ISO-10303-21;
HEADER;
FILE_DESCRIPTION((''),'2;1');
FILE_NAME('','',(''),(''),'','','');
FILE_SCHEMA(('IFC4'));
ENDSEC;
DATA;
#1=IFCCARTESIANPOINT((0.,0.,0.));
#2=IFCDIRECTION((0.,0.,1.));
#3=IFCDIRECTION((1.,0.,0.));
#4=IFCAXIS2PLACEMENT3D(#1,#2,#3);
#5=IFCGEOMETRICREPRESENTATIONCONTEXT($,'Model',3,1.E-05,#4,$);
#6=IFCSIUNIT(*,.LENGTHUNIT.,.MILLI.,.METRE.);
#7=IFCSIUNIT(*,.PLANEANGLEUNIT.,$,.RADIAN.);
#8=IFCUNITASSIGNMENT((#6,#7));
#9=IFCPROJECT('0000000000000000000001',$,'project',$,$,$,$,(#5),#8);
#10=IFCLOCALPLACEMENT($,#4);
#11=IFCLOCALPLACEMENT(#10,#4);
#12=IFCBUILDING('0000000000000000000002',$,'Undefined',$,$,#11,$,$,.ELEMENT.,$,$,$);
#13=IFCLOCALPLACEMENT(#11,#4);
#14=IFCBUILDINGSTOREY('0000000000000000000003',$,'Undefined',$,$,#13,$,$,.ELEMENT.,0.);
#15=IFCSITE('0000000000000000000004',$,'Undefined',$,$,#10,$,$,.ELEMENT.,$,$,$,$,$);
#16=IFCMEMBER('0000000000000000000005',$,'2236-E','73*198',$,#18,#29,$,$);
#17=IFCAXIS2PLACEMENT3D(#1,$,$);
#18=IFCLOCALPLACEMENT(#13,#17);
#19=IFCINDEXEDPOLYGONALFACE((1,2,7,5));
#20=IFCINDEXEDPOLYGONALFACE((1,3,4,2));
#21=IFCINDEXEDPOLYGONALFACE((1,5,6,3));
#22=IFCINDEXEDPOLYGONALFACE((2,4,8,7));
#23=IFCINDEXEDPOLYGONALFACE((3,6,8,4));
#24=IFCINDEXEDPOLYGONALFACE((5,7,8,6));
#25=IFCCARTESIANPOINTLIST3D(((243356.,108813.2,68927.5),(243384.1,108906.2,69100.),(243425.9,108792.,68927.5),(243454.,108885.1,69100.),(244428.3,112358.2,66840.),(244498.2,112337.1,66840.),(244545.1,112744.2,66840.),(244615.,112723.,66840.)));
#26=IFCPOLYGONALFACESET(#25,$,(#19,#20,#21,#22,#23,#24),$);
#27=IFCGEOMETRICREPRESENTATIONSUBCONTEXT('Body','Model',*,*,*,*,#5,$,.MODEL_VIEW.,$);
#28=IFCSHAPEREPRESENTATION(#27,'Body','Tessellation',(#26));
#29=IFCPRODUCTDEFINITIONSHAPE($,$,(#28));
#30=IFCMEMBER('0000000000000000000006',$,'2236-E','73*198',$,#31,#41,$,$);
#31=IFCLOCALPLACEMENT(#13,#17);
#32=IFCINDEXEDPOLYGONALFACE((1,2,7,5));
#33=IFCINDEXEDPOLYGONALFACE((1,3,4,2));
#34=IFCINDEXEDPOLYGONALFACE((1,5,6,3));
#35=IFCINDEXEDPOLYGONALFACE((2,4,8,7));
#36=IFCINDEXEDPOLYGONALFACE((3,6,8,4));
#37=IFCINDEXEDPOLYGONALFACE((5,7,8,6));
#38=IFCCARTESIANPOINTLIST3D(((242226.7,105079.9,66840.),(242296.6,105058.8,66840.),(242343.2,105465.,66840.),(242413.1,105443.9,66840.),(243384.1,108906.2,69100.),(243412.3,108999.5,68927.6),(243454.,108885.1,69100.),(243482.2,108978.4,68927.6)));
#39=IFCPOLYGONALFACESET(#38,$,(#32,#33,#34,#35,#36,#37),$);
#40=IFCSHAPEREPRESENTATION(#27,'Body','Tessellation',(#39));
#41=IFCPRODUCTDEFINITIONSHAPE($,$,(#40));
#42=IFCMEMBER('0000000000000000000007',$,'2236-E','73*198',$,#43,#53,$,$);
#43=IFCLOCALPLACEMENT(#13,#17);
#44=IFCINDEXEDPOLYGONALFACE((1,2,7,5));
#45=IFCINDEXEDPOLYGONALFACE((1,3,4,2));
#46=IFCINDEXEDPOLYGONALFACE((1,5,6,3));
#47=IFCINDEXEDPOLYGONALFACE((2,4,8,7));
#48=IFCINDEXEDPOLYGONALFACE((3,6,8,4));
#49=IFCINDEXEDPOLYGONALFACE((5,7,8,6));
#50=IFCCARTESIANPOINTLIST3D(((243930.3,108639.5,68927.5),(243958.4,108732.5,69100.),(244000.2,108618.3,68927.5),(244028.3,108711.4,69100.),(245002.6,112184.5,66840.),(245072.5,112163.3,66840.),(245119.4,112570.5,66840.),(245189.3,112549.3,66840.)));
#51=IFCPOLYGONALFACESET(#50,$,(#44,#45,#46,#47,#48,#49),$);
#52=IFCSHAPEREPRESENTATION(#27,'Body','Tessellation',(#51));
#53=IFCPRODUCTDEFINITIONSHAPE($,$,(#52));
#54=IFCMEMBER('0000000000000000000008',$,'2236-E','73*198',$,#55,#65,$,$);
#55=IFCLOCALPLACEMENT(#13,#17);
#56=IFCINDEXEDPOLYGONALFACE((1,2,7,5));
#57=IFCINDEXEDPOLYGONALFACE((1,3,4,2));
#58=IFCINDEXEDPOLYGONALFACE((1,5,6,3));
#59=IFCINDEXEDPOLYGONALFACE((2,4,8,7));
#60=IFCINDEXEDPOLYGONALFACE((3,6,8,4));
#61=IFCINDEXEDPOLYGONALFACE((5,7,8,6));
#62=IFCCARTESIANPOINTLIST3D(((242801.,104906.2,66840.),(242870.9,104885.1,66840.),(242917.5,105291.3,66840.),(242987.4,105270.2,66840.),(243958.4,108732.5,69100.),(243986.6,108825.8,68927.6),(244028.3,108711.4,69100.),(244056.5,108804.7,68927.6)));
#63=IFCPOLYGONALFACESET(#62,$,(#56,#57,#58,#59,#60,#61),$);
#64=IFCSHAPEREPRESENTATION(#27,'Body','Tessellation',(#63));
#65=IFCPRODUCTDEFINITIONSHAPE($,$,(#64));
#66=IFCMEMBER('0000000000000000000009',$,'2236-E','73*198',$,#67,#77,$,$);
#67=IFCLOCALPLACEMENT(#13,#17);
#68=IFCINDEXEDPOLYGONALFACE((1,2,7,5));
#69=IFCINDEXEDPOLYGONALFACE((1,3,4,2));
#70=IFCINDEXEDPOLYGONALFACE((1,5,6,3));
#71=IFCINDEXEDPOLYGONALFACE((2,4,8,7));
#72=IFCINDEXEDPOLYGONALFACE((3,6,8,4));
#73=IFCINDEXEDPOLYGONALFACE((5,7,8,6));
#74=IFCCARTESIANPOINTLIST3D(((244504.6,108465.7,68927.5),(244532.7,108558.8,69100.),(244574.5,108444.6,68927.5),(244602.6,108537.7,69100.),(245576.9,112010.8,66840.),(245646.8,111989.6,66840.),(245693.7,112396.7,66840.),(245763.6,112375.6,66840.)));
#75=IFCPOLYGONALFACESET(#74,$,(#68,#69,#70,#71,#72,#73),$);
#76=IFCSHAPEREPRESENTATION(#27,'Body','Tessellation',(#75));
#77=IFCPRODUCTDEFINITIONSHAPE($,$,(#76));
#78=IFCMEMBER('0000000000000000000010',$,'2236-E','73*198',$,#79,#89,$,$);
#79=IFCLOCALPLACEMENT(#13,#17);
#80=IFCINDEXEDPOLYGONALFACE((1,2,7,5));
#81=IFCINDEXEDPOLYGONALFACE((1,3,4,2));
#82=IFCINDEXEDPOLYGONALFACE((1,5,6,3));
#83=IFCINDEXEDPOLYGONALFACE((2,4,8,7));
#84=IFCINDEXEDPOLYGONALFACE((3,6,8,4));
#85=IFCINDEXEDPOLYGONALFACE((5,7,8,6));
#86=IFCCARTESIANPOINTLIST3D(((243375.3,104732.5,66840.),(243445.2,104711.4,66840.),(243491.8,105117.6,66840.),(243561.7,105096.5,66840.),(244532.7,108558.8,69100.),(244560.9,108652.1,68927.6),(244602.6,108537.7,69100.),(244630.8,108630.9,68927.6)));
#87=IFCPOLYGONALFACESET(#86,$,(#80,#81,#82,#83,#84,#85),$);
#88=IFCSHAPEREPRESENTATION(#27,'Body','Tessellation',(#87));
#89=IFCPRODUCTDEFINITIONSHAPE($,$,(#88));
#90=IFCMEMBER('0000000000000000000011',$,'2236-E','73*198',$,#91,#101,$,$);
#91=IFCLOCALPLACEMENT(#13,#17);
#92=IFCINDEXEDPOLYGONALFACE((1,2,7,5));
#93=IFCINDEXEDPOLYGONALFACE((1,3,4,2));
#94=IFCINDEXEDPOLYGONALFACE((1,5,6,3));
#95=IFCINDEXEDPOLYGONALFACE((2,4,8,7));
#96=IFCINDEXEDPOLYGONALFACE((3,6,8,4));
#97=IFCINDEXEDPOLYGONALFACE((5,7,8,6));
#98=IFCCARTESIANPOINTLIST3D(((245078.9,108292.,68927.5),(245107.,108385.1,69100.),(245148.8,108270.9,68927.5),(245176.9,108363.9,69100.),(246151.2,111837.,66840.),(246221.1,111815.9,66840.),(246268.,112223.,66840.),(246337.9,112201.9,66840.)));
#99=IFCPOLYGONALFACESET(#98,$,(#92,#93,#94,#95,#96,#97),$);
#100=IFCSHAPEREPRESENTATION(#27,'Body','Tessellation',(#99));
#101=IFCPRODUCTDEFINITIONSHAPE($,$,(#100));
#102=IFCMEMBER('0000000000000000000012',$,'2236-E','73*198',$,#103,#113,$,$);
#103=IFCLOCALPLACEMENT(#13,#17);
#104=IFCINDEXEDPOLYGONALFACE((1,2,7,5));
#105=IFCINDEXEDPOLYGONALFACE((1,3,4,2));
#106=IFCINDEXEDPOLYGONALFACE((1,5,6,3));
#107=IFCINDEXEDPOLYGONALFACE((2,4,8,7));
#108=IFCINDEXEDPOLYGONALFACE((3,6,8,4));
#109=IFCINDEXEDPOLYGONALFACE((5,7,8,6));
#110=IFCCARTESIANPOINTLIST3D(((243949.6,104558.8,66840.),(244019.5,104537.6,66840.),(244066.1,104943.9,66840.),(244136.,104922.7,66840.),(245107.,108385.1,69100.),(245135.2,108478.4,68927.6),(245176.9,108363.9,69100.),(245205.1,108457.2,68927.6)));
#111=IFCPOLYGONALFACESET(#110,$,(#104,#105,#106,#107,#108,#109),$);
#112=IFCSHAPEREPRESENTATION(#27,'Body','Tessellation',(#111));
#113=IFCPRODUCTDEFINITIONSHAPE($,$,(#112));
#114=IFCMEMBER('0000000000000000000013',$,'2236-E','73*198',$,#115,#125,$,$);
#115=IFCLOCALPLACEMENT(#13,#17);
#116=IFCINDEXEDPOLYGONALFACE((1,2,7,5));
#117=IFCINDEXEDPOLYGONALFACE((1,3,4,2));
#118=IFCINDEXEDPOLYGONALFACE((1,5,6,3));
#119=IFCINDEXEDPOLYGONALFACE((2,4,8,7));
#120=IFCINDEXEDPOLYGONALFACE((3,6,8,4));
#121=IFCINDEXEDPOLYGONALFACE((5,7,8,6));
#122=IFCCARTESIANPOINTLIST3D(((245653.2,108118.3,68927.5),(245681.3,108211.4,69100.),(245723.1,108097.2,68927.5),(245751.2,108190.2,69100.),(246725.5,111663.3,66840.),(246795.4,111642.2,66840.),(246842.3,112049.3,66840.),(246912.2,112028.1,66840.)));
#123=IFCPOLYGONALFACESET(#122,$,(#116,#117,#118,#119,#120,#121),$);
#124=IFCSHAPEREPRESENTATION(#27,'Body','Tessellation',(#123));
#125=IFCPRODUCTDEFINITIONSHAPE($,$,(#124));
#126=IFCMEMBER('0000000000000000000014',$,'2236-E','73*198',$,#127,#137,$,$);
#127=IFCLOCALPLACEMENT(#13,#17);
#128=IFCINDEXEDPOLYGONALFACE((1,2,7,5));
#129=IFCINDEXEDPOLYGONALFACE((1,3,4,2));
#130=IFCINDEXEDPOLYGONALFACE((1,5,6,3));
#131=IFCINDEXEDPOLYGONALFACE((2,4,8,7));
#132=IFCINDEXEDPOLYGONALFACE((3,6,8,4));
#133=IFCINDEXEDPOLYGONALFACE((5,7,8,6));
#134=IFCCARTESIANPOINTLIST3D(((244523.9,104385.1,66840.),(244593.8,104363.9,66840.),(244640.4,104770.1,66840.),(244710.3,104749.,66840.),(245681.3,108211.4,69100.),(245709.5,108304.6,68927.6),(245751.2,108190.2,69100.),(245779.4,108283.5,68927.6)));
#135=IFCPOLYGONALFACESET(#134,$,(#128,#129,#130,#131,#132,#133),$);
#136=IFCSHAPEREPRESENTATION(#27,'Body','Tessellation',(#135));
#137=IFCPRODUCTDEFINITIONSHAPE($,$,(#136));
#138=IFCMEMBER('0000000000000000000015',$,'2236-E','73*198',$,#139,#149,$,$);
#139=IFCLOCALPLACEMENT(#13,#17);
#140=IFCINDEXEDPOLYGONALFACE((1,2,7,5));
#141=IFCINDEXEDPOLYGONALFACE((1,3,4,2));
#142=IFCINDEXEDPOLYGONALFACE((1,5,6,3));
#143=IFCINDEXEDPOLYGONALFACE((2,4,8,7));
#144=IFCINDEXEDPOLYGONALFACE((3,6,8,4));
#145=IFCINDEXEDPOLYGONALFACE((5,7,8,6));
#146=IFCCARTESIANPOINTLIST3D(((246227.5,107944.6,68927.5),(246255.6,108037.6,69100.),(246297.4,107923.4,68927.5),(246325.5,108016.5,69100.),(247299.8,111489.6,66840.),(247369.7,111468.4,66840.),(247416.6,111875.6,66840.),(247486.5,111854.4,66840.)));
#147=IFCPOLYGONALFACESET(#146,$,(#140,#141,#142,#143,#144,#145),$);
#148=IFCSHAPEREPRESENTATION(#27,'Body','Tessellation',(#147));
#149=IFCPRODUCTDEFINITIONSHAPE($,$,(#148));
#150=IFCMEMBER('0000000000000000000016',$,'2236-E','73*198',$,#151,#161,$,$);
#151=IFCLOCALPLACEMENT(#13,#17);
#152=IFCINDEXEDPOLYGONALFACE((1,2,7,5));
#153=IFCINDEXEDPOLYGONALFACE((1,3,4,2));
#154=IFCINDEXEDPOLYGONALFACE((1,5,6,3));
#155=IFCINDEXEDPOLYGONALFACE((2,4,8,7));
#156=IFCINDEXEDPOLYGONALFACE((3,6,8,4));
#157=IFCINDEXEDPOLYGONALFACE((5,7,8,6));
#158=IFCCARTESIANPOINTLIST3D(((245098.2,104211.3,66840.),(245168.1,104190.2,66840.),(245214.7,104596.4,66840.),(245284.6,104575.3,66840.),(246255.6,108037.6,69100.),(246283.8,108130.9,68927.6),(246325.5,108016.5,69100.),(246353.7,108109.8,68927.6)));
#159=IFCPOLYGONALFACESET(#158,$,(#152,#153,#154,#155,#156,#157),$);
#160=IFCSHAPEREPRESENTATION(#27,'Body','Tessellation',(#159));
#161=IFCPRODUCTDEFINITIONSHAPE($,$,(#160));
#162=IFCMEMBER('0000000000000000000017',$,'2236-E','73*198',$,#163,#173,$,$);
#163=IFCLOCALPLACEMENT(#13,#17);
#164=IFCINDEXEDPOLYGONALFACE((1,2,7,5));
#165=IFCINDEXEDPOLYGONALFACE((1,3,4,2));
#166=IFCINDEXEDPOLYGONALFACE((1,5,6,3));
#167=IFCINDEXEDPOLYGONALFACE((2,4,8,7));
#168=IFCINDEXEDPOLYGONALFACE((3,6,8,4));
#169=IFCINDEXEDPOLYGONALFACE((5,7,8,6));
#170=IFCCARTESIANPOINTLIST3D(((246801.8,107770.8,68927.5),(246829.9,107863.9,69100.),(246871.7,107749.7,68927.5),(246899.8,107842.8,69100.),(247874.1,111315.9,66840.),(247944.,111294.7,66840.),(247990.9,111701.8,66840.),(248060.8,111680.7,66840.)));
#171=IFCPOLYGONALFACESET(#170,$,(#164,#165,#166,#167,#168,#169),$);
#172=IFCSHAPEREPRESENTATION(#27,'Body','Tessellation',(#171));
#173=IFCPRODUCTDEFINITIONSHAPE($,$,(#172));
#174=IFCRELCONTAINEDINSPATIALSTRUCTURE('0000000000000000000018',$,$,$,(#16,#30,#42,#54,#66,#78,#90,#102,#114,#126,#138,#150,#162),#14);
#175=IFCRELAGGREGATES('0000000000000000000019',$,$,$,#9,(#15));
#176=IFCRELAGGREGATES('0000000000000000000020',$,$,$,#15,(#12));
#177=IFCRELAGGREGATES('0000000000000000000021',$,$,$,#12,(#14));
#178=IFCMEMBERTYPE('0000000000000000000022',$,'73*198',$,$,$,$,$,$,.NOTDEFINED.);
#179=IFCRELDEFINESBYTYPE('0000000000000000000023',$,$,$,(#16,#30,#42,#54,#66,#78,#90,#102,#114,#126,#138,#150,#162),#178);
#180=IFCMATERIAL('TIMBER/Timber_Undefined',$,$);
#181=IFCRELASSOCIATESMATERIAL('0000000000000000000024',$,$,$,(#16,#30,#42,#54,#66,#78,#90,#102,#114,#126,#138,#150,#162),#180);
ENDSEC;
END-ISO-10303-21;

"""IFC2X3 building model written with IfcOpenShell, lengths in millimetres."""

from ifc_helpers import new_model, si_unit, frame, origin_with_axes, origin_2d_with_axis, place, context, subcontext, project, spatial, rectangle, extrude, clip, halfspace, material, type_object, element, save


model = new_model("IFC2X3")

# Units and contexts
model_context = context("Model", 3, precision=1e-05, world=origin_with_axes())
body_context = subcontext(model_context, "Body", "Model", "MODEL_VIEW")
ifc_project = project(units=[si_unit("LENGTHUNIT", "METRE", prefix="MILLI"), si_unit("PLANEANGLEUNIT", "RADIAN")], contexts=[model_context])

# Site, building, storey
site_placement = place(None, origin_with_axes())
site = spatial("IfcSite", under=ifc_project, at=site_placement, Name="Undefined", CompositionType="ELEMENT")
building_placement = place(site_placement, origin_with_axes())
building = spatial("IfcBuilding", under=site, at=building_placement, Name="Undefined", CompositionType="ELEMENT")
storey_placement = place(building_placement, origin_with_axes())
storey = spatial("IfcBuildingStorey", under=building, at=storey_placement, Name="Undefined", CompositionType="ELEMENT", Elevation=0.0)

# Shared definitions
ifc_material_1 = material(Name="TIMBER/Timber_Undefined")

# Members
member_type = type_object("IfcMemberType", Name="73*198", PredefinedType="NOTDEFINED")
member_1_placement = place(storey_placement, frame((243405.0, 108849.1, 69013.8), z_axis=(-0.957167, 0.289538, 0.0), x_axis=(0.252232, 0.833838, -0.491013)))
element("IfcMember", 1, at=member_1_placement, inside=storey, type_object=member_type, material=ifc_material_1, Name="2236-E", Description="73*198", context=body_context, shape_type="Clipping", body=[
    clip(extrude(rectangle(XDim=198.0, YDim=73.0, at=origin_2d_with_axis()), frame((9470.2, 0.0, 0.0), z_axis=(-1.0, 0.0, 0.0), x_axis=(0.0, -1.0, 0.0)), (0.0, 0.0, 1.0), 9470.2), halfspace(frame((4746.2, -179.9, -36.5), z_axis=(0.491013, 0.871152, 0.0), x_axis=(0.0, 0.0, 1.0)), False)),
])
member_2_placement = place(storey_placement, frame((243433.2, 108942.3, 69013.8), z_axis=(-0.957167, 0.289538, 0.0), x_axis=(-0.252047, -0.833226, -0.492144)))
element("IfcMember", 2, at=member_2_placement, inside=storey, type_object=member_type, material=ifc_material_1, Name="2236-E", Description="73*198", context=body_context, shape_type="Clipping", body=[
    clip(extrude(rectangle(XDim=198.0, YDim=73.0, at=origin_2d_with_axis()), frame((9448.4, 0.0, 0.0), z_axis=(-1.0, 0.0, 0.0), x_axis=(0.0, -1.0, 0.0)), (0.0, 0.0, 1.0), 9448.5), halfspace(frame((4746.1, 186.1, 36.5), z_axis=(0.492144, -0.870514, 0.0), x_axis=(0.0, 0.0, -1.0)), False)),
])
member_3_placement = place(storey_placement, frame((243979.3, 108675.4, 69013.8), z_axis=(-0.957167, 0.289538, 0.0), x_axis=(0.252232, 0.833838, -0.491013)))
element("IfcMember", 3, at=member_3_placement, inside=storey, type_object=member_type, material=ifc_material_1, Name="2236-E", Description="73*198", context=body_context, shape_type="Clipping", body=[
    clip(extrude(rectangle(XDim=198.0, YDim=73.0, at=origin_2d_with_axis()), frame((9470.2, 0.0, 0.0), z_axis=(-1.0, 0.0, 0.0), x_axis=(0.0, -1.0, 0.0)), (0.0, 0.0, 1.0), 9470.2), halfspace(frame((4746.2, -179.9, -36.5), z_axis=(0.491013, 0.871152, 0.0), x_axis=(0.0, 0.0, 1.0)), False)),
])
member_4_placement = place(storey_placement, frame((244007.5, 108768.6, 69013.8), z_axis=(-0.957167, 0.289538, 0.0), x_axis=(-0.252047, -0.833226, -0.492144)))
element("IfcMember", 4, at=member_4_placement, inside=storey, type_object=member_type, material=ifc_material_1, Name="2236-E", Description="73*198", context=body_context, shape_type="Clipping", body=[
    clip(extrude(rectangle(XDim=198.0, YDim=73.0, at=origin_2d_with_axis()), frame((9448.4, 0.0, 0.0), z_axis=(-1.0, 0.0, 0.0), x_axis=(0.0, -1.0, 0.0)), (0.0, 0.0, 1.0), 9448.5), halfspace(frame((4746.1, 186.1, 36.5), z_axis=(0.492144, -0.870514, 0.0), x_axis=(0.0, 0.0, -1.0)), False)),
])
member_5_placement = place(storey_placement, frame((244553.6, 108501.7, 69013.8), z_axis=(-0.957167, 0.289538, 0.0), x_axis=(0.252232, 0.833838, -0.491013)))
element("IfcMember", 5, at=member_5_placement, inside=storey, type_object=member_type, material=ifc_material_1, Name="2236-E", Description="73*198", context=body_context, shape_type="Clipping", body=[
    clip(extrude(rectangle(XDim=198.0, YDim=73.0, at=origin_2d_with_axis()), frame((9470.2, 0.0, 0.0), z_axis=(-1.0, 0.0, 0.0), x_axis=(0.0, -1.0, 0.0)), (0.0, 0.0, 1.0), 9470.2), halfspace(frame((4746.2, -179.9, -36.5), z_axis=(0.491013, 0.871152, 0.0), x_axis=(0.0, 0.0, 1.0)), False)),
])
member_6_placement = place(storey_placement, frame((244581.8, 108594.9, 69013.8), z_axis=(-0.957167, 0.289538, 0.0), x_axis=(-0.252047, -0.833226, -0.492144)))
element("IfcMember", 6, at=member_6_placement, inside=storey, type_object=member_type, material=ifc_material_1, Name="2236-E", Description="73*198", context=body_context, shape_type="Clipping", body=[
    clip(extrude(rectangle(XDim=198.0, YDim=73.0, at=origin_2d_with_axis()), frame((9448.4, 0.0, 0.0), z_axis=(-1.0, 0.0, 0.0), x_axis=(0.0, -1.0, 0.0)), (0.0, 0.0, 1.0), 9448.5), halfspace(frame((4746.1, 186.1, 36.5), z_axis=(0.492144, -0.870514, 0.0), x_axis=(0.0, 0.0, -1.0)), False)),
])
member_7_placement = place(storey_placement, frame((245127.9, 108328.0, 69013.8), z_axis=(-0.957167, 0.289538, 0.0), x_axis=(0.252232, 0.833838, -0.491013)))
element("IfcMember", 7, at=member_7_placement, inside=storey, type_object=member_type, material=ifc_material_1, Name="2236-E", Description="73*198", context=body_context, shape_type="Clipping", body=[
    clip(extrude(rectangle(XDim=198.0, YDim=73.0, at=origin_2d_with_axis()), frame((9470.2, 0.0, 0.0), z_axis=(-1.0, 0.0, 0.0), x_axis=(0.0, -1.0, 0.0)), (0.0, 0.0, 1.0), 9470.2), halfspace(frame((4746.2, -179.9, -36.5), z_axis=(0.491013, 0.871152, 0.0), x_axis=(0.0, 0.0, 1.0)), False)),
])
member_8_placement = place(storey_placement, frame((245156.1, 108421.1, 69013.8), z_axis=(-0.957167, 0.289538, 0.0), x_axis=(-0.252047, -0.833226, -0.492144)))
element("IfcMember", 8, at=member_8_placement, inside=storey, type_object=member_type, material=ifc_material_1, Name="2236-E", Description="73*198", context=body_context, shape_type="Clipping", body=[
    clip(extrude(rectangle(XDim=198.0, YDim=73.0, at=origin_2d_with_axis()), frame((9448.4, 0.0, 0.0), z_axis=(-1.0, 0.0, 0.0), x_axis=(0.0, -1.0, 0.0)), (0.0, 0.0, 1.0), 9448.5), halfspace(frame((4746.1, 186.1, 36.5), z_axis=(0.492144, -0.870514, 0.0), x_axis=(0.0, 0.0, -1.0)), False)),
])
member_9_placement = place(storey_placement, frame((245702.2, 108154.3, 69013.8), z_axis=(-0.957167, 0.289538, 0.0), x_axis=(0.252232, 0.833838, -0.491013)))
element("IfcMember", 9, at=member_9_placement, inside=storey, type_object=member_type, material=ifc_material_1, Name="2236-E", Description="73*198", context=body_context, shape_type="Clipping", body=[
    clip(extrude(rectangle(XDim=198.0, YDim=73.0, at=origin_2d_with_axis()), frame((9470.2, 0.0, 0.0), z_axis=(-1.0, 0.0, 0.0), x_axis=(0.0, -1.0, 0.0)), (0.0, 0.0, 1.0), 9470.2), halfspace(frame((4746.2, -179.9, -36.5), z_axis=(0.491013, 0.871152, 0.0), x_axis=(0.0, 0.0, 1.0)), False)),
])
member_10_placement = place(storey_placement, frame((245730.4, 108247.4, 69013.8), z_axis=(-0.957167, 0.289538, 0.0), x_axis=(-0.252047, -0.833226, -0.492144)))
element("IfcMember", 10, at=member_10_placement, inside=storey, type_object=member_type, material=ifc_material_1, Name="2236-E", Description="73*198", context=body_context, shape_type="Clipping", body=[
    clip(extrude(rectangle(XDim=198.0, YDim=73.0, at=origin_2d_with_axis()), frame((9448.4, 0.0, 0.0), z_axis=(-1.0, 0.0, 0.0), x_axis=(0.0, -1.0, 0.0)), (0.0, 0.0, 1.0), 9448.5), halfspace(frame((4746.1, 186.1, 36.5), z_axis=(0.492144, -0.870514, 0.0), x_axis=(0.0, 0.0, -1.0)), False)),
])
member_11_placement = place(storey_placement, frame((246276.5, 107980.5, 69013.8), z_axis=(-0.957167, 0.289538, 0.0), x_axis=(0.252232, 0.833838, -0.491013)))
element("IfcMember", 11, at=member_11_placement, inside=storey, type_object=member_type, material=ifc_material_1, Name="2236-E", Description="73*198", context=body_context, shape_type="Clipping", body=[
    clip(extrude(rectangle(XDim=198.0, YDim=73.0, at=origin_2d_with_axis()), frame((9470.2, 0.0, 0.0), z_axis=(-1.0, 0.0, 0.0), x_axis=(0.0, -1.0, 0.0)), (0.0, 0.0, 1.0), 9470.2), halfspace(frame((4746.2, -179.9, -36.5), z_axis=(0.491013, 0.871152, 0.0), x_axis=(0.0, 0.0, 1.0)), False)),
])
member_12_placement = place(storey_placement, frame((246304.7, 108073.7, 69013.8), z_axis=(-0.957167, 0.289538, 0.0), x_axis=(-0.252047, -0.833226, -0.492144)))
element("IfcMember", 12, at=member_12_placement, inside=storey, type_object=member_type, material=ifc_material_1, Name="2236-E", Description="73*198", context=body_context, shape_type="Clipping", body=[
    clip(extrude(rectangle(XDim=198.0, YDim=73.0, at=origin_2d_with_axis()), frame((9448.4, 0.0, 0.0), z_axis=(-1.0, 0.0, 0.0), x_axis=(0.0, -1.0, 0.0)), (0.0, 0.0, 1.0), 9448.5), halfspace(frame((4746.1, 186.1, 36.5), z_axis=(0.492144, -0.870514, 0.0), x_axis=(0.0, 0.0, -1.0)), False)),
])
member_13_placement = place(storey_placement, frame((246850.8, 107806.8, 69013.8), z_axis=(-0.957167, 0.289538, 0.0), x_axis=(0.252232, 0.833838, -0.491013)))
element("IfcMember", 13, at=member_13_placement, inside=storey, type_object=member_type, material=ifc_material_1, Name="2236-E", Description="73*198", context=body_context, shape_type="Clipping", body=[
    clip(extrude(rectangle(XDim=198.0, YDim=73.0, at=origin_2d_with_axis()), frame((9470.2, 0.0, 0.0), z_axis=(-1.0, 0.0, 0.0), x_axis=(0.0, -1.0, 0.0)), (0.0, 0.0, 1.0), 9470.2), halfspace(frame((4746.2, -179.9, -36.5), z_axis=(0.491013, 0.871152, 0.0), x_axis=(0.0, 0.0, 1.0)), False)),
])

save(model, "model.ifc")
